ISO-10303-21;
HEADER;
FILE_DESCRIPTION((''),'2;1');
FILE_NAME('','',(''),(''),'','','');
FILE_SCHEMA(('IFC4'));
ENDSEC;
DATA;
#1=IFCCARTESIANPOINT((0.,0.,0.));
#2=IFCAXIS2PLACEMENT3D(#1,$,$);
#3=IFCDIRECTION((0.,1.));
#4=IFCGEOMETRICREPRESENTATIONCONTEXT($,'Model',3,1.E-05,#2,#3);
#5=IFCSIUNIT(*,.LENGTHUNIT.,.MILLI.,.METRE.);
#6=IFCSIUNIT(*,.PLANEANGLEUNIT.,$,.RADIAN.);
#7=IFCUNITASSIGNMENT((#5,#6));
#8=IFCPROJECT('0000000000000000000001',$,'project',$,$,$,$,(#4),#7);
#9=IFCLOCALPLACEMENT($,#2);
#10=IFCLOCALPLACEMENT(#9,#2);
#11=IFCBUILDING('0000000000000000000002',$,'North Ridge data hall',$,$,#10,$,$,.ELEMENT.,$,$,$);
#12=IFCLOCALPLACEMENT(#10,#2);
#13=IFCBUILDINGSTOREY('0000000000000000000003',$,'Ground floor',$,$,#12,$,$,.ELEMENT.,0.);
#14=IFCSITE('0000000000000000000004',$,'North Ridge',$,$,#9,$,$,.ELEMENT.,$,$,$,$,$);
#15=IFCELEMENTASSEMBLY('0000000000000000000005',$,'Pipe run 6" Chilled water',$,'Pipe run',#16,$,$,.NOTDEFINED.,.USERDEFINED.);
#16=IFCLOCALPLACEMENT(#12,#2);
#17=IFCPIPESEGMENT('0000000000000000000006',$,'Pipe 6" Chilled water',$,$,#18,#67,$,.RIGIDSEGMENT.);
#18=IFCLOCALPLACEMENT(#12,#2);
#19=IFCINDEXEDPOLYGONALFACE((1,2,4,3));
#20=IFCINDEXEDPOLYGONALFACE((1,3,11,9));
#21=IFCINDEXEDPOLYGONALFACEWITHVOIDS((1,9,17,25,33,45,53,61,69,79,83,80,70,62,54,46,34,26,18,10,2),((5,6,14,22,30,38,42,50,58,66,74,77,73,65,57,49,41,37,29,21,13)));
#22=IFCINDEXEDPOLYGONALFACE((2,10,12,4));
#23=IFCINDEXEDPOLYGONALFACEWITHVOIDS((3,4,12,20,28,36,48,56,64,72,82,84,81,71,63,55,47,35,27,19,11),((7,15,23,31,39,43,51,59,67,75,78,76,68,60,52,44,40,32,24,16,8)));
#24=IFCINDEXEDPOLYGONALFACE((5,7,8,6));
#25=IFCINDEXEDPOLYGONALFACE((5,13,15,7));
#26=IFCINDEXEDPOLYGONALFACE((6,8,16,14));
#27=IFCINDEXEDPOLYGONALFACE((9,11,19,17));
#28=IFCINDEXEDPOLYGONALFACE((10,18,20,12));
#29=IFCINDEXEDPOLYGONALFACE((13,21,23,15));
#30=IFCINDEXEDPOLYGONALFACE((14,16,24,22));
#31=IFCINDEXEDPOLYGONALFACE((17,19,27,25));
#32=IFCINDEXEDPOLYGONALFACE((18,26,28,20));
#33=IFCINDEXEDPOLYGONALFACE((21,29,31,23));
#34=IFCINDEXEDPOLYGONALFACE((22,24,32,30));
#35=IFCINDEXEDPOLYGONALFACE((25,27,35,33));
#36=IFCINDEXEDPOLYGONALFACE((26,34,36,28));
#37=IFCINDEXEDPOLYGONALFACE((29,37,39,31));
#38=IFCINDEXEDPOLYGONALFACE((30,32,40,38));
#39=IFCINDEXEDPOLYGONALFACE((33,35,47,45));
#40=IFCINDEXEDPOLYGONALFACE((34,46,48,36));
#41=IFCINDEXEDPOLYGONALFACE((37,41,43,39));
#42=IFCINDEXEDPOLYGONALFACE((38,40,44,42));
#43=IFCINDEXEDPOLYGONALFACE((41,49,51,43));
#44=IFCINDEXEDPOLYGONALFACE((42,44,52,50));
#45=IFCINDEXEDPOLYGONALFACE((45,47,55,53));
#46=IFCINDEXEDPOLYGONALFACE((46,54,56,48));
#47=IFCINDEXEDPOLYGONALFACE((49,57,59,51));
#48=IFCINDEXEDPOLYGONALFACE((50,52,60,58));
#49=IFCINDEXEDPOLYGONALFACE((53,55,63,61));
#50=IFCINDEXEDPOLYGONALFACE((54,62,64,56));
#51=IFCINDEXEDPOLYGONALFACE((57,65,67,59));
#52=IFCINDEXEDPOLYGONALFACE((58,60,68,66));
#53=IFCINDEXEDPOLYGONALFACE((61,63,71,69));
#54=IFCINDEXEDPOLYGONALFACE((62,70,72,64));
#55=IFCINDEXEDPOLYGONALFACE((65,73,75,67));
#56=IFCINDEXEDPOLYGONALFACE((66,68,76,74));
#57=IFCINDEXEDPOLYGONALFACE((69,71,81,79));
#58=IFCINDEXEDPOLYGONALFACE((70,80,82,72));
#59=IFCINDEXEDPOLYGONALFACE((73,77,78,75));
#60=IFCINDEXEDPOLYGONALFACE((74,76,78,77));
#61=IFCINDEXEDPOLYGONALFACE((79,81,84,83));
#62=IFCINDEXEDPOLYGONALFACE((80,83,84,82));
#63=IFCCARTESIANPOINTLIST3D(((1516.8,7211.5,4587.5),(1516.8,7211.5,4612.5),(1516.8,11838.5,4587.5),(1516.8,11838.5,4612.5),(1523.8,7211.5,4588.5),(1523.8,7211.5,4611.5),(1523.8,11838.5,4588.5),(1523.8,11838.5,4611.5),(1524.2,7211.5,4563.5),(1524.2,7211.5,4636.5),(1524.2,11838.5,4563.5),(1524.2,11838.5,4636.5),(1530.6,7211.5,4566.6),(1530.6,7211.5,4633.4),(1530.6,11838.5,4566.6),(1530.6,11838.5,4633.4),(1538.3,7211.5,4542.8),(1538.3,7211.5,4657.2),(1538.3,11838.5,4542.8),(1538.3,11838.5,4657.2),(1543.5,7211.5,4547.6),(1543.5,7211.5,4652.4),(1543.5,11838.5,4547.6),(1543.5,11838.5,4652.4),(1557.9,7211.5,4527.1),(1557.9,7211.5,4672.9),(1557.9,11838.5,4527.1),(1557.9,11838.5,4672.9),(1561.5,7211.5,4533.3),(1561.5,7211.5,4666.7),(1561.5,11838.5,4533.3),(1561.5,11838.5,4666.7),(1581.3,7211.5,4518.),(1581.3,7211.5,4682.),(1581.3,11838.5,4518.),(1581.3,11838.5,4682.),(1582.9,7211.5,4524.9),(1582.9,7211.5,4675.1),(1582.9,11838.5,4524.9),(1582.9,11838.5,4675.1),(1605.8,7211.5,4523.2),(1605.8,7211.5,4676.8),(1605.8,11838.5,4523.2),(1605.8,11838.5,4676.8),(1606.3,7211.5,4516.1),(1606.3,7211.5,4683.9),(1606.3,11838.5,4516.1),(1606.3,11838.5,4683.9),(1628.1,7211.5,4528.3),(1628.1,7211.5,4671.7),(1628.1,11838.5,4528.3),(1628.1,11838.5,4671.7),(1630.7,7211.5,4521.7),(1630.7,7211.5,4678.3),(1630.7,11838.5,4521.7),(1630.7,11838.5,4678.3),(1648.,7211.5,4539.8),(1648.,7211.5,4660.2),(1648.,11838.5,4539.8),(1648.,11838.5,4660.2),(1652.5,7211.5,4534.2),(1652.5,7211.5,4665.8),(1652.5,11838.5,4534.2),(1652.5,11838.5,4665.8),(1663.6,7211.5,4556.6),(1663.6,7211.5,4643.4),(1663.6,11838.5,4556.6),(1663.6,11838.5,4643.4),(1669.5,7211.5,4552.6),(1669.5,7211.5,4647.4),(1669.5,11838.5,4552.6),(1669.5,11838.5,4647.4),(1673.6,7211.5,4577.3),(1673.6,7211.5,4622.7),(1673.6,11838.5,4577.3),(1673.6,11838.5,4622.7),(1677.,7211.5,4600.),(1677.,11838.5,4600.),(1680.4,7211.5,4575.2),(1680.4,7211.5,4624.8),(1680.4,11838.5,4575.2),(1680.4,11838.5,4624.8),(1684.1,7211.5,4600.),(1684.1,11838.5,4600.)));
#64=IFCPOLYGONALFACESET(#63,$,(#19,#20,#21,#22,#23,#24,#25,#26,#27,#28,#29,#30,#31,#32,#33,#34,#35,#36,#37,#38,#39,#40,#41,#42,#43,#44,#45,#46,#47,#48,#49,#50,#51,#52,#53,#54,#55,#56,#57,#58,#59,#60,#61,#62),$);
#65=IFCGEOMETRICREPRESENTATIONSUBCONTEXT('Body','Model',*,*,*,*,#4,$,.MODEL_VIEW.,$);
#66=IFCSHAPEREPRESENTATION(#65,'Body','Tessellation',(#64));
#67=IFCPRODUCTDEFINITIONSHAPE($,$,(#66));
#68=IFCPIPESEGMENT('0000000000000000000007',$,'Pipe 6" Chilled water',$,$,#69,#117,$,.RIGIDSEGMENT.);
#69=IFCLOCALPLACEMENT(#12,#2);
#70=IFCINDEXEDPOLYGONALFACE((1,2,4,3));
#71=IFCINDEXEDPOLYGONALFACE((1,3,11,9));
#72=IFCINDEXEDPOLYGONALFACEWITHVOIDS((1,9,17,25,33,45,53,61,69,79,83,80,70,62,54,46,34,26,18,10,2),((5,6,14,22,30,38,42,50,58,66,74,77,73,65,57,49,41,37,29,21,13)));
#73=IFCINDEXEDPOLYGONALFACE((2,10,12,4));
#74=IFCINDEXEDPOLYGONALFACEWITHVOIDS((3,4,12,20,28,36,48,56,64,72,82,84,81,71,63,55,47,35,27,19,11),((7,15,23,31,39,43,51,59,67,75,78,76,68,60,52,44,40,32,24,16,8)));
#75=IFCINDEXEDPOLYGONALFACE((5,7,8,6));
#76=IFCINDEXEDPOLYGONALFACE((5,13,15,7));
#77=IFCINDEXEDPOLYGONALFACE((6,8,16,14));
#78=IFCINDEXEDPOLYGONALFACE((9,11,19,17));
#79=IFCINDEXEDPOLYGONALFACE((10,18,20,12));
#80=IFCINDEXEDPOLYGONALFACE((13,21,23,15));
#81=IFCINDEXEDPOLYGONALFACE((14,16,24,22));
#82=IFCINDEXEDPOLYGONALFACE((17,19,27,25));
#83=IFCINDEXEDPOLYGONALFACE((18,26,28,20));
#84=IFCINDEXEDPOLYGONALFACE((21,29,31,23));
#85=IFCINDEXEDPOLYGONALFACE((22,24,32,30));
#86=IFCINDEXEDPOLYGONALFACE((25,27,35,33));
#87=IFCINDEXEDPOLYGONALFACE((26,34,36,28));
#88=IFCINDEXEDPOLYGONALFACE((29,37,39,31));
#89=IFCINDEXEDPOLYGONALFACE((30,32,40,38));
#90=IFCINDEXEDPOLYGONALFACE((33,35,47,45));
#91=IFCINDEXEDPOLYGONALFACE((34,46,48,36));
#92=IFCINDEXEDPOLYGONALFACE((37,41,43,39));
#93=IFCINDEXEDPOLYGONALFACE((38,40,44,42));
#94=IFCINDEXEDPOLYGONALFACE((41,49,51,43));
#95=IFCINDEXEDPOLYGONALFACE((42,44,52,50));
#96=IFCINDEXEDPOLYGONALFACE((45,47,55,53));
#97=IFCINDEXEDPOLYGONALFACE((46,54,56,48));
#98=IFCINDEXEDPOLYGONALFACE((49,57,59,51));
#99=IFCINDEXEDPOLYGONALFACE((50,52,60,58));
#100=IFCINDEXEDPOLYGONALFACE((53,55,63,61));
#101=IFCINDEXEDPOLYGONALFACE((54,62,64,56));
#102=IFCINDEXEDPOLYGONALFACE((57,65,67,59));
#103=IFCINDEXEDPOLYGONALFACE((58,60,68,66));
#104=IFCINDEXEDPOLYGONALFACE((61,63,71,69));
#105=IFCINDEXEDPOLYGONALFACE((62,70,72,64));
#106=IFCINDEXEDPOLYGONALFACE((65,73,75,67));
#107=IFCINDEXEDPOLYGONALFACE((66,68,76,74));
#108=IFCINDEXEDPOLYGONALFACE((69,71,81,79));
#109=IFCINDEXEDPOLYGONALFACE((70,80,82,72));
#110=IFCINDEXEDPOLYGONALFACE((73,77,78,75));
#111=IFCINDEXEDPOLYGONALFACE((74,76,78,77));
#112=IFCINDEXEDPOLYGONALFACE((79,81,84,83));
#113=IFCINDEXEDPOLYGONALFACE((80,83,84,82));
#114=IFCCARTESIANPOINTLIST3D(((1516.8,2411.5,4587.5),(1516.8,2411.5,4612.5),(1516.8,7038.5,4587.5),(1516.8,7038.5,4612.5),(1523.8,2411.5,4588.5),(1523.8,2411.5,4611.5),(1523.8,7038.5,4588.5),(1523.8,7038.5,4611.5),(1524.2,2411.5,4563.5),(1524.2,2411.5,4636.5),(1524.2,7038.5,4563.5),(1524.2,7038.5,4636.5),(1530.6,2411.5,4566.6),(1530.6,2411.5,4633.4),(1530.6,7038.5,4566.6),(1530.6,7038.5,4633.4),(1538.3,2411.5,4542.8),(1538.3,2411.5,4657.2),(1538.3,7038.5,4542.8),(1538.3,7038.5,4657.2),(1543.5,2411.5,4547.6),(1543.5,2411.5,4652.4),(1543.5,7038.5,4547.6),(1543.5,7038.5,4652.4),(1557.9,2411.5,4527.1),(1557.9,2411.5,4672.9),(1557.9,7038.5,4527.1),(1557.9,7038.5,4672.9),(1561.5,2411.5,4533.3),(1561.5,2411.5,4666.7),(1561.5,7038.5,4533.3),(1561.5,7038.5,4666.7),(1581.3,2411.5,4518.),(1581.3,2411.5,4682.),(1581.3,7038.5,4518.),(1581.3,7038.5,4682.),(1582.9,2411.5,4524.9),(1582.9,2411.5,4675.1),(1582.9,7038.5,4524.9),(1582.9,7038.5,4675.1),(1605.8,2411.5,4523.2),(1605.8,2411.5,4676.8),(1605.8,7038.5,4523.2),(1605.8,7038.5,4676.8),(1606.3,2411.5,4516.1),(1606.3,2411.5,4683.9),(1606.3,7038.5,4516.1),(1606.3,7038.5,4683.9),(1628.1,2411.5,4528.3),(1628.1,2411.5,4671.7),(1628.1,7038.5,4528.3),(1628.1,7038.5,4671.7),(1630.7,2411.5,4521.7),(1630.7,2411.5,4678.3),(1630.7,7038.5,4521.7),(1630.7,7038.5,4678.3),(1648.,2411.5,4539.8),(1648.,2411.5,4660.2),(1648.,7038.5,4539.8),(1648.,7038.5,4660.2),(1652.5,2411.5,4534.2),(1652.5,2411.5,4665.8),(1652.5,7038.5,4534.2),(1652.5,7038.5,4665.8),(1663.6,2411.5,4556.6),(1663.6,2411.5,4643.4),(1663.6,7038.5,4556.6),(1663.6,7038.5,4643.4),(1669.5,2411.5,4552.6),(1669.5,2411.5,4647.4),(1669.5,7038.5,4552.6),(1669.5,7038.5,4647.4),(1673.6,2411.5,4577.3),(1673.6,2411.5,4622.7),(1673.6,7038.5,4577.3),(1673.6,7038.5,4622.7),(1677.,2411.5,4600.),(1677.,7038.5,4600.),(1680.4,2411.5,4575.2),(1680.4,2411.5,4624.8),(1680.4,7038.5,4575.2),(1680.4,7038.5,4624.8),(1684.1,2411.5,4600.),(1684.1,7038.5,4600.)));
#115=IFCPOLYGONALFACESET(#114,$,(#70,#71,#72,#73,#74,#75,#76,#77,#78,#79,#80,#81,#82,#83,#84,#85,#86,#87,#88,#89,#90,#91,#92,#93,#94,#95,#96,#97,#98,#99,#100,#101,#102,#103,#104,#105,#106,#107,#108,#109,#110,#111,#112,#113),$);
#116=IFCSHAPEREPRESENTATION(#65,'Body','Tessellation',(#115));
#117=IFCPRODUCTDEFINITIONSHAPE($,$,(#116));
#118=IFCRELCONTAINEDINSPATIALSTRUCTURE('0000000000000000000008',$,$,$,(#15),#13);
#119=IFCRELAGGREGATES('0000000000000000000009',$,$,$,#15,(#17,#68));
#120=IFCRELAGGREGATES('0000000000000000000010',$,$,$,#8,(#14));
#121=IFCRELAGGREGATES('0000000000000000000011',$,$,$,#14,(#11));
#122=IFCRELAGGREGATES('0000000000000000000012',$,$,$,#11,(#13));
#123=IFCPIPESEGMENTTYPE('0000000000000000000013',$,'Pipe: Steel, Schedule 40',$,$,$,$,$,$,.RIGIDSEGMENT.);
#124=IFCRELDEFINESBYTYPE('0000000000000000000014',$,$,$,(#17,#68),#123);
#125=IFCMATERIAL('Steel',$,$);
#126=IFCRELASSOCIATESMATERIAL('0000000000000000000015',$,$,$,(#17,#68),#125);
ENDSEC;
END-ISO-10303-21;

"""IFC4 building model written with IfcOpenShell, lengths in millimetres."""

from ifc_helpers import new_model, si_unit, direction, frame, origin, origin_with_axes, origin_2d, place, context, subcontext, project, spatial, hollow_circle, extrude, material, type_object, element, aggregate, save


model = new_model("IFC4")

# Units and contexts
model_context = context("Model", 3, precision=1e-05, world=origin(), true_north=direction((0.0, 1.0)))
body_context = subcontext(model_context, "Body", "Model", "MODEL_VIEW")
ifc_project = project(units=[si_unit("LENGTHUNIT", "METRE", prefix="MILLI"), si_unit("PLANEANGLEUNIT", "RADIAN")], contexts=[model_context])

# Site, building, storey
site_placement = place(None, origin())
site = spatial("IfcSite", under=ifc_project, at=site_placement, Name="North Ridge", CompositionType="ELEMENT")
building_placement = place(site_placement, origin())
building = spatial("IfcBuilding", under=site, at=building_placement, Name="North Ridge data hall", CompositionType="ELEMENT")
storey_placement = place(building_placement, origin())
storey = spatial("IfcBuildingStorey", under=building, at=storey_placement, Name="Ground floor", CompositionType="ELEMENT", Elevation=0.0)

# Element assembly, pipe segments
ifc_material_1 = material(Name="Steel")
pipe_segment_type = type_object("IfcPipeSegmentType", Name="Pipe: Steel, Schedule 40", PredefinedType="RIGIDSEGMENT")
assembly_1_placement = place(storey_placement, origin_with_axes())
assembly_1 = element("IfcElementAssembly", 1, at=assembly_1_placement, inside=storey, Name="Pipe run 6\" Chilled water", ObjectType="Pipe run", AssemblyPlace="NOTDEFINED", PredefinedType="USERDEFINED")
pipe_segment_1_placement = place(storey_placement, origin_with_axes())
pipe_segment_1 = element("IfcPipeSegment", 2, at=pipe_segment_1_placement, type_object=pipe_segment_type, material=ifc_material_1, Name="Pipe 6\" Chilled water", PredefinedType="RIGIDSEGMENT", context=body_context, shape_type="SweptSolid", body=[
    extrude(hollow_circle(Radius=84.1, WallThickness=7.1, at=origin_2d()), frame((1600.0, 11838.5, 4600.0), z_axis=(0.0, -1.0, 0.0), x_axis=(1.0, 0.0, 0.0)), (0.0, 0.0, 1.0), 4627.0),
])
pipe_segment_2_placement = place(storey_placement, origin_with_axes())
pipe_segment_2 = element("IfcPipeSegment", 3, at=pipe_segment_2_placement, type_object=pipe_segment_type, material=ifc_material_1, Name="Pipe 6\" Chilled water", PredefinedType="RIGIDSEGMENT", context=body_context, shape_type="SweptSolid", body=[
    extrude(hollow_circle(Radius=84.1, WallThickness=7.1, at=origin_2d()), frame((1600.0, 7038.5, 4600.0), z_axis=(0.0, -1.0, 0.0), x_axis=(1.0, 0.0, 0.0)), (0.0, 0.0, 1.0), 4627.0),
])

aggregate(assembly_1, [pipe_segment_1, pipe_segment_2])

save(model, "model.ifc")
